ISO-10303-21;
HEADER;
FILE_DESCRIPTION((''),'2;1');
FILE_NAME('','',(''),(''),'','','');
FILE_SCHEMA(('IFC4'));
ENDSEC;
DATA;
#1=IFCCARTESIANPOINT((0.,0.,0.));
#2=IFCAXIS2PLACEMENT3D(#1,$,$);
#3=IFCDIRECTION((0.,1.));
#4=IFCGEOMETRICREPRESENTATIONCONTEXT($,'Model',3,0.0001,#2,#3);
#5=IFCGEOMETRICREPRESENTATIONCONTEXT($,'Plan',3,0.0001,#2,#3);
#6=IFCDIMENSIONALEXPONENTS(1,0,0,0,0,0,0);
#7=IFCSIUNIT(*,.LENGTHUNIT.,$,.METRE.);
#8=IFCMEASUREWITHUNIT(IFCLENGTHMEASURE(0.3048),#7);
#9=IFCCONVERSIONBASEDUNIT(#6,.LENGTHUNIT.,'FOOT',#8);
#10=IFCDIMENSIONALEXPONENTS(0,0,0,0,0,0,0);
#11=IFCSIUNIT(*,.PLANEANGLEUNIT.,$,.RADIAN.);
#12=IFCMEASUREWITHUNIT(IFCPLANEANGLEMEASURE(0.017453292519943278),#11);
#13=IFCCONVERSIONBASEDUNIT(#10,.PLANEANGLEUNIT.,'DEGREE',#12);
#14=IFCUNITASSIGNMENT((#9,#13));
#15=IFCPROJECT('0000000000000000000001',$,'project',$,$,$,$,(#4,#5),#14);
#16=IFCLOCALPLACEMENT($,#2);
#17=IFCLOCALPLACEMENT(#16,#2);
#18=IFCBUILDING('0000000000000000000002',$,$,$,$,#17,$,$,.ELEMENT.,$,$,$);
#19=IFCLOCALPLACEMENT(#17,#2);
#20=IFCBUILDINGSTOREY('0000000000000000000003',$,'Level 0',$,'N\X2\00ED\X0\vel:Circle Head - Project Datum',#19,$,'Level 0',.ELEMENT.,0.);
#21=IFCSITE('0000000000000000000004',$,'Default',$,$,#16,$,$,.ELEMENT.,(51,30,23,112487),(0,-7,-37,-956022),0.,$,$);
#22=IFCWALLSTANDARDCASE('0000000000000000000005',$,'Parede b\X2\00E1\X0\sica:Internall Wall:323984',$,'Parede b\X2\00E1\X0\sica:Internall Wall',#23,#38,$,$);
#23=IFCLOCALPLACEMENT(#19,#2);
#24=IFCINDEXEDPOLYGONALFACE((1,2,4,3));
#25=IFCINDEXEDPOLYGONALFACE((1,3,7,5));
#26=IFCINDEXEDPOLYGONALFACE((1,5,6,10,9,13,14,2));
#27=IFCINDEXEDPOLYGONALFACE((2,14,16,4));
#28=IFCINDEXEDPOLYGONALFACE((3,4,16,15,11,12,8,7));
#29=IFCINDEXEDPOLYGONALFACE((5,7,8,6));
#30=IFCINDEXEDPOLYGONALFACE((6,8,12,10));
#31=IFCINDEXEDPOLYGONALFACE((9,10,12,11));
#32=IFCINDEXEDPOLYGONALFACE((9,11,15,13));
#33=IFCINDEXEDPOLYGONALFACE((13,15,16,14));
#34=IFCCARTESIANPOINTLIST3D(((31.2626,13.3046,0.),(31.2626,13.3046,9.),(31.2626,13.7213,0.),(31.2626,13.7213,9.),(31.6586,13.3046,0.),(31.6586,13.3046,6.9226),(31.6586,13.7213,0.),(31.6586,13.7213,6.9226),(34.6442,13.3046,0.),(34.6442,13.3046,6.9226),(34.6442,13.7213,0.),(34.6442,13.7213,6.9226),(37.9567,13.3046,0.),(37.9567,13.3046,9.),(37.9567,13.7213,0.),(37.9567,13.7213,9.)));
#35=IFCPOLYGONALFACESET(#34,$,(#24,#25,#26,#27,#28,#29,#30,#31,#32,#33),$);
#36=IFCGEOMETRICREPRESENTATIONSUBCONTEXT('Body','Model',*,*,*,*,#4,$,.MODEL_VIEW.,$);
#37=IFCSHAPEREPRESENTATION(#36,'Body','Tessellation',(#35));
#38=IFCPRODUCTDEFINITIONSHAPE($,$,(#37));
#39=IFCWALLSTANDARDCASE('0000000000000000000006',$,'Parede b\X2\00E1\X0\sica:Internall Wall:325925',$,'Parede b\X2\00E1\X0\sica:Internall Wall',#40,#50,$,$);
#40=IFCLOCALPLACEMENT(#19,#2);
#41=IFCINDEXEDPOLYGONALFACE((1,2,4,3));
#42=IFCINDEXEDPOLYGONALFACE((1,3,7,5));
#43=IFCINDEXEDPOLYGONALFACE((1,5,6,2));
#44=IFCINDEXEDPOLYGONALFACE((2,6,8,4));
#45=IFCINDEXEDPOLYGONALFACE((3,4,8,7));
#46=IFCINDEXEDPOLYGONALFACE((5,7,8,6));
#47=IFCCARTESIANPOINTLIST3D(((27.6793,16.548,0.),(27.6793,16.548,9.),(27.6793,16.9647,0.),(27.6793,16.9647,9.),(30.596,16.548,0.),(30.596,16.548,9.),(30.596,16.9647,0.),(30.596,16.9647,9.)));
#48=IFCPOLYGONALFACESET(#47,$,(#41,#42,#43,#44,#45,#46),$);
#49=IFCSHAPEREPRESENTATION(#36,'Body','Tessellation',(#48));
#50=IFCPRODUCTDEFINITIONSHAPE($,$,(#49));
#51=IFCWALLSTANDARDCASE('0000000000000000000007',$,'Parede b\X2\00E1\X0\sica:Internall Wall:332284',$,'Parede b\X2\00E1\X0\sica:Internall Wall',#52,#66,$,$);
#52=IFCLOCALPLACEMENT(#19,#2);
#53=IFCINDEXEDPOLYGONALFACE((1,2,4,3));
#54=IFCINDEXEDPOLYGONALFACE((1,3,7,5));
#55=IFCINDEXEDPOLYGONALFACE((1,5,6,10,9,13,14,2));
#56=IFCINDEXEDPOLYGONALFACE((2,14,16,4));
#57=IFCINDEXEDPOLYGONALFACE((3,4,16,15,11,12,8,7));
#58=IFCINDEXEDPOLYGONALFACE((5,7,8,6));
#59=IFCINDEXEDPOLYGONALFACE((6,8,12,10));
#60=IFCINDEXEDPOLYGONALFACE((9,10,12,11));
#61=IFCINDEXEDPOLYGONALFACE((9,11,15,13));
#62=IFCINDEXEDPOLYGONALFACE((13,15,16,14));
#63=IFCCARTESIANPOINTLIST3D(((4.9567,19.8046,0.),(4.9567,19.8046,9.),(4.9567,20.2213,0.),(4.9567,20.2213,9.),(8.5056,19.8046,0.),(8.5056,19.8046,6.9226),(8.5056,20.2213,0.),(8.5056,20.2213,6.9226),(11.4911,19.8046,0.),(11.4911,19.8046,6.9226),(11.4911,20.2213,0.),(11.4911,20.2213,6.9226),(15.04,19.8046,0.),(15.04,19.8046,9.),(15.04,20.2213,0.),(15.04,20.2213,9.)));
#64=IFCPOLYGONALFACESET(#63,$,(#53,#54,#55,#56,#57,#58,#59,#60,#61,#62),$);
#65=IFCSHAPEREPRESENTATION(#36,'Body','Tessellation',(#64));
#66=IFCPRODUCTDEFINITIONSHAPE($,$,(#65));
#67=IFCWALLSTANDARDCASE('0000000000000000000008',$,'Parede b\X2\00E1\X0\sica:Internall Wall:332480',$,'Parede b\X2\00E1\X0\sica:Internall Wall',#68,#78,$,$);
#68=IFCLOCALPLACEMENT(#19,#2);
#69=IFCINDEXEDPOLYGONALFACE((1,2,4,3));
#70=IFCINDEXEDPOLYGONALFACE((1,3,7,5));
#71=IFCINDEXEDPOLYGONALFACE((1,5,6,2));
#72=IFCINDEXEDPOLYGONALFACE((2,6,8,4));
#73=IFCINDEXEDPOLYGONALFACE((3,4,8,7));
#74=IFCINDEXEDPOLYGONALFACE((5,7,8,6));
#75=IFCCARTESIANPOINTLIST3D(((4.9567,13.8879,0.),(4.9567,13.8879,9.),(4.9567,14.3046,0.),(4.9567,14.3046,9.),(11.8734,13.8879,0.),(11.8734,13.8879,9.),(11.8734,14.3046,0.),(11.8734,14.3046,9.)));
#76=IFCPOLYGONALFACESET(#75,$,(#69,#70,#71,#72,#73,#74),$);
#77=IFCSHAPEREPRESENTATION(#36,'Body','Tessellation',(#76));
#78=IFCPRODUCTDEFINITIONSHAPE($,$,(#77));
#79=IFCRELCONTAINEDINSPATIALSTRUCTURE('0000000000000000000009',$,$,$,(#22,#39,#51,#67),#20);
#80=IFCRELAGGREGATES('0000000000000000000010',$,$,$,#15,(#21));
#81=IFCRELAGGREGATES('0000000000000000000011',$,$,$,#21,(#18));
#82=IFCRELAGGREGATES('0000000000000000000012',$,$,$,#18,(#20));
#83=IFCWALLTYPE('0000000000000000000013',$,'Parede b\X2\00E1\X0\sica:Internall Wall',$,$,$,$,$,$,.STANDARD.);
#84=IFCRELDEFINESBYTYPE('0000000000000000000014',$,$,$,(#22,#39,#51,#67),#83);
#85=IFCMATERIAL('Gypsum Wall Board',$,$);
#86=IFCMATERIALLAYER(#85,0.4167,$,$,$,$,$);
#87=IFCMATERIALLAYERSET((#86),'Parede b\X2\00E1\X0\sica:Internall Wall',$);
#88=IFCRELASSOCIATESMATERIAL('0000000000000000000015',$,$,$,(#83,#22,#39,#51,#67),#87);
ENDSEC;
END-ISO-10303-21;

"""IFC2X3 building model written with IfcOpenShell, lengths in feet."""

from ifc_helpers import new_model, entity, si_unit, converted_unit, direction, frame, frame_2d, origin, place, context, subcontext, project, spatial, rectangle, extrude, material, layer, layer_set, layer_usage, type_object, element, save


model = new_model("IFC2X3")

# Units and contexts
model_context = context("Model", 3, precision=0.0001, world=origin(), true_north=direction((0.0, 1.0)))
plan_context = context("Plan", 3, precision=0.0001, world=origin(), true_north=direction((0.0, 1.0)))
body_context = subcontext(model_context, "Body", "Model", "MODEL_VIEW")
ifc_project = project(units=[converted_unit("LENGTHUNIT", "FOOT", entity("IfcLengthMeasure", 0.3048), si_unit("LENGTHUNIT", "METRE"), dimensions=[1, 0, 0, 0, 0, 0, 0]), converted_unit("PLANEANGLEUNIT", "DEGREE", entity("IfcPlaneAngleMeasure", 0.017453292519943278), si_unit("PLANEANGLEUNIT", "RADIAN"), dimensions=[0, 0, 0, 0, 0, 0, 0])], contexts=[model_context, plan_context])

# Site, building, storey
site_placement = place(None, origin())
site = spatial("IfcSite", under=ifc_project, at=site_placement, Name="Default", CompositionType="ELEMENT", RefLatitude=(51, 30, 23, 112487), RefLongitude=(0, -7, -37, -956022), RefElevation=0.0)
building_placement = place(site_placement, origin())
building = spatial("IfcBuilding", under=site, at=building_placement, CompositionType="ELEMENT")
storey_placement = place(building_placement, origin())
storey = spatial("IfcBuildingStorey", under=building, at=storey_placement, Name="Level 0", ObjectType="Nível:Circle Head - Project Datum", LongName="Level 0", CompositionType="ELEMENT", Elevation=0.0)

# Shared definitions
ifc_material_1 = material(Name="Gypsum Wall Board")
ifc_layer_1 = layer(ifc_material_1, 0.4167)
ifc_layer_set_1 = layer_set([ifc_layer_1], Name="Parede básica:Internall Wall")
wall_type_1 = type_object("IfcWallType", Name="Parede básica:Internall Wall", PredefinedType="STANDARD", material=ifc_layer_set_1)

# Wall, opening
ifc_layer_usage_1 = layer_usage(ifc_layer_set_1, "AXIS2", "NEGATIVE", 0.2083)
wall_1_placement = place(storey_placement, frame((37.9567, 13.5129, 0.0), z_axis=(0.0, 0.0, 1.0), x_axis=(-1.0, 0.0, 0.0)))
wall_1 = element("IfcWallStandardCase", 1, at=wall_1_placement, inside=storey, type_object=wall_type_1, material=ifc_layer_usage_1, Name="Parede básica:Internall Wall:323984", ObjectType="Parede básica:Internall Wall", context=body_context, shape_type="SweptSolid", body=[
    extrude(rectangle(XDim=6.6941, YDim=0.4167, at=frame_2d((3.347, 0.0), x_axis=(1.0, 0.0))), origin(), (0.0, 0.0, 1.0), 9.0),
])
opening_1_placement = place(wall_1_placement, frame((6.2981, 0.2083, 0.0)))
element("IfcOpeningElement", 2, at=opening_1_placement, cuts=wall_1, ObjectType="Opening", context=body_context, shape_type="SweptSolid", body=[
    extrude(rectangle(XDim=6.9226, YDim=2.9856, at=frame_2d((3.4613, 1.4928), x_axis=(1.0, 0.0))), frame((0.0, 0.0, 0.0), z_axis=(0.0, -1.0, 0.0), x_axis=(0.0, 0.0, 1.0)), (0.0, 0.0, 1.0), 0.4167),
])

# Wall
ifc_layer_usage_2 = layer_usage(ifc_layer_set_1, "AXIS2", "NEGATIVE", 0.2083)
wall_2_placement = place(storey_placement, frame((27.6793, 16.7564, 0.0)))
element("IfcWallStandardCase", 3, at=wall_2_placement, inside=storey, type_object=wall_type_1, material=ifc_layer_usage_2, Name="Parede básica:Internall Wall:325925", ObjectType="Parede básica:Internall Wall", context=body_context, shape_type="SweptSolid", body=[
    extrude(rectangle(XDim=2.9167, YDim=0.4167, at=frame_2d((1.4583, 0.0), x_axis=(-1.0, 0.0))), origin(), (0.0, 0.0, 1.0), 9.0),
])

# Wall, opening
ifc_layer_usage_3 = layer_usage(ifc_layer_set_1, "AXIS2", "NEGATIVE", 0.2083)
wall_3_placement = place(storey_placement, frame((4.9567, 20.0129, 0.0)))
wall_3 = element("IfcWallStandardCase", 4, at=wall_3_placement, inside=storey, type_object=wall_type_1, material=ifc_layer_usage_3, Name="Parede básica:Internall Wall:332284", ObjectType="Parede básica:Internall Wall", context=body_context, shape_type="SweptSolid", body=[
    extrude(rectangle(XDim=10.0833, YDim=0.4167, at=frame_2d((5.0417, 0.0), x_axis=(1.0, 0.0))), origin(), (0.0, 0.0, 1.0), 9.0),
])
opening_2_placement = place(wall_3_placement, frame((6.5344, 0.2083, 0.0)))
element("IfcOpeningElement", 5, at=opening_2_placement, cuts=wall_3, ObjectType="Opening", context=body_context, shape_type="SweptSolid", body=[
    extrude(rectangle(XDim=6.9226, YDim=2.9856, at=frame_2d((3.4613, 1.4928), x_axis=(1.0, 0.0))), frame((0.0, 0.0, 0.0), z_axis=(0.0, -1.0, 0.0), x_axis=(0.0, 0.0, 1.0)), (0.0, 0.0, 1.0), 0.4167),
])

# Wall
ifc_layer_usage_4 = layer_usage(ifc_layer_set_1, "AXIS2", "NEGATIVE", 0.2083)
wall_4_placement = place(storey_placement, frame((4.9567, 14.0963, 0.0)))
element("IfcWallStandardCase", 6, at=wall_4_placement, inside=storey, type_object=wall_type_1, material=ifc_layer_usage_4, Name="Parede básica:Internall Wall:332480", ObjectType="Parede básica:Internall Wall", context=body_context, shape_type="SweptSolid", body=[
    extrude(rectangle(XDim=6.9167, YDim=0.4167, at=frame_2d((3.4583, 0.0), x_axis=(-1.0, 0.0))), origin(), (0.0, 0.0, 1.0), 9.0),
])

save(model, "model.ifc")
